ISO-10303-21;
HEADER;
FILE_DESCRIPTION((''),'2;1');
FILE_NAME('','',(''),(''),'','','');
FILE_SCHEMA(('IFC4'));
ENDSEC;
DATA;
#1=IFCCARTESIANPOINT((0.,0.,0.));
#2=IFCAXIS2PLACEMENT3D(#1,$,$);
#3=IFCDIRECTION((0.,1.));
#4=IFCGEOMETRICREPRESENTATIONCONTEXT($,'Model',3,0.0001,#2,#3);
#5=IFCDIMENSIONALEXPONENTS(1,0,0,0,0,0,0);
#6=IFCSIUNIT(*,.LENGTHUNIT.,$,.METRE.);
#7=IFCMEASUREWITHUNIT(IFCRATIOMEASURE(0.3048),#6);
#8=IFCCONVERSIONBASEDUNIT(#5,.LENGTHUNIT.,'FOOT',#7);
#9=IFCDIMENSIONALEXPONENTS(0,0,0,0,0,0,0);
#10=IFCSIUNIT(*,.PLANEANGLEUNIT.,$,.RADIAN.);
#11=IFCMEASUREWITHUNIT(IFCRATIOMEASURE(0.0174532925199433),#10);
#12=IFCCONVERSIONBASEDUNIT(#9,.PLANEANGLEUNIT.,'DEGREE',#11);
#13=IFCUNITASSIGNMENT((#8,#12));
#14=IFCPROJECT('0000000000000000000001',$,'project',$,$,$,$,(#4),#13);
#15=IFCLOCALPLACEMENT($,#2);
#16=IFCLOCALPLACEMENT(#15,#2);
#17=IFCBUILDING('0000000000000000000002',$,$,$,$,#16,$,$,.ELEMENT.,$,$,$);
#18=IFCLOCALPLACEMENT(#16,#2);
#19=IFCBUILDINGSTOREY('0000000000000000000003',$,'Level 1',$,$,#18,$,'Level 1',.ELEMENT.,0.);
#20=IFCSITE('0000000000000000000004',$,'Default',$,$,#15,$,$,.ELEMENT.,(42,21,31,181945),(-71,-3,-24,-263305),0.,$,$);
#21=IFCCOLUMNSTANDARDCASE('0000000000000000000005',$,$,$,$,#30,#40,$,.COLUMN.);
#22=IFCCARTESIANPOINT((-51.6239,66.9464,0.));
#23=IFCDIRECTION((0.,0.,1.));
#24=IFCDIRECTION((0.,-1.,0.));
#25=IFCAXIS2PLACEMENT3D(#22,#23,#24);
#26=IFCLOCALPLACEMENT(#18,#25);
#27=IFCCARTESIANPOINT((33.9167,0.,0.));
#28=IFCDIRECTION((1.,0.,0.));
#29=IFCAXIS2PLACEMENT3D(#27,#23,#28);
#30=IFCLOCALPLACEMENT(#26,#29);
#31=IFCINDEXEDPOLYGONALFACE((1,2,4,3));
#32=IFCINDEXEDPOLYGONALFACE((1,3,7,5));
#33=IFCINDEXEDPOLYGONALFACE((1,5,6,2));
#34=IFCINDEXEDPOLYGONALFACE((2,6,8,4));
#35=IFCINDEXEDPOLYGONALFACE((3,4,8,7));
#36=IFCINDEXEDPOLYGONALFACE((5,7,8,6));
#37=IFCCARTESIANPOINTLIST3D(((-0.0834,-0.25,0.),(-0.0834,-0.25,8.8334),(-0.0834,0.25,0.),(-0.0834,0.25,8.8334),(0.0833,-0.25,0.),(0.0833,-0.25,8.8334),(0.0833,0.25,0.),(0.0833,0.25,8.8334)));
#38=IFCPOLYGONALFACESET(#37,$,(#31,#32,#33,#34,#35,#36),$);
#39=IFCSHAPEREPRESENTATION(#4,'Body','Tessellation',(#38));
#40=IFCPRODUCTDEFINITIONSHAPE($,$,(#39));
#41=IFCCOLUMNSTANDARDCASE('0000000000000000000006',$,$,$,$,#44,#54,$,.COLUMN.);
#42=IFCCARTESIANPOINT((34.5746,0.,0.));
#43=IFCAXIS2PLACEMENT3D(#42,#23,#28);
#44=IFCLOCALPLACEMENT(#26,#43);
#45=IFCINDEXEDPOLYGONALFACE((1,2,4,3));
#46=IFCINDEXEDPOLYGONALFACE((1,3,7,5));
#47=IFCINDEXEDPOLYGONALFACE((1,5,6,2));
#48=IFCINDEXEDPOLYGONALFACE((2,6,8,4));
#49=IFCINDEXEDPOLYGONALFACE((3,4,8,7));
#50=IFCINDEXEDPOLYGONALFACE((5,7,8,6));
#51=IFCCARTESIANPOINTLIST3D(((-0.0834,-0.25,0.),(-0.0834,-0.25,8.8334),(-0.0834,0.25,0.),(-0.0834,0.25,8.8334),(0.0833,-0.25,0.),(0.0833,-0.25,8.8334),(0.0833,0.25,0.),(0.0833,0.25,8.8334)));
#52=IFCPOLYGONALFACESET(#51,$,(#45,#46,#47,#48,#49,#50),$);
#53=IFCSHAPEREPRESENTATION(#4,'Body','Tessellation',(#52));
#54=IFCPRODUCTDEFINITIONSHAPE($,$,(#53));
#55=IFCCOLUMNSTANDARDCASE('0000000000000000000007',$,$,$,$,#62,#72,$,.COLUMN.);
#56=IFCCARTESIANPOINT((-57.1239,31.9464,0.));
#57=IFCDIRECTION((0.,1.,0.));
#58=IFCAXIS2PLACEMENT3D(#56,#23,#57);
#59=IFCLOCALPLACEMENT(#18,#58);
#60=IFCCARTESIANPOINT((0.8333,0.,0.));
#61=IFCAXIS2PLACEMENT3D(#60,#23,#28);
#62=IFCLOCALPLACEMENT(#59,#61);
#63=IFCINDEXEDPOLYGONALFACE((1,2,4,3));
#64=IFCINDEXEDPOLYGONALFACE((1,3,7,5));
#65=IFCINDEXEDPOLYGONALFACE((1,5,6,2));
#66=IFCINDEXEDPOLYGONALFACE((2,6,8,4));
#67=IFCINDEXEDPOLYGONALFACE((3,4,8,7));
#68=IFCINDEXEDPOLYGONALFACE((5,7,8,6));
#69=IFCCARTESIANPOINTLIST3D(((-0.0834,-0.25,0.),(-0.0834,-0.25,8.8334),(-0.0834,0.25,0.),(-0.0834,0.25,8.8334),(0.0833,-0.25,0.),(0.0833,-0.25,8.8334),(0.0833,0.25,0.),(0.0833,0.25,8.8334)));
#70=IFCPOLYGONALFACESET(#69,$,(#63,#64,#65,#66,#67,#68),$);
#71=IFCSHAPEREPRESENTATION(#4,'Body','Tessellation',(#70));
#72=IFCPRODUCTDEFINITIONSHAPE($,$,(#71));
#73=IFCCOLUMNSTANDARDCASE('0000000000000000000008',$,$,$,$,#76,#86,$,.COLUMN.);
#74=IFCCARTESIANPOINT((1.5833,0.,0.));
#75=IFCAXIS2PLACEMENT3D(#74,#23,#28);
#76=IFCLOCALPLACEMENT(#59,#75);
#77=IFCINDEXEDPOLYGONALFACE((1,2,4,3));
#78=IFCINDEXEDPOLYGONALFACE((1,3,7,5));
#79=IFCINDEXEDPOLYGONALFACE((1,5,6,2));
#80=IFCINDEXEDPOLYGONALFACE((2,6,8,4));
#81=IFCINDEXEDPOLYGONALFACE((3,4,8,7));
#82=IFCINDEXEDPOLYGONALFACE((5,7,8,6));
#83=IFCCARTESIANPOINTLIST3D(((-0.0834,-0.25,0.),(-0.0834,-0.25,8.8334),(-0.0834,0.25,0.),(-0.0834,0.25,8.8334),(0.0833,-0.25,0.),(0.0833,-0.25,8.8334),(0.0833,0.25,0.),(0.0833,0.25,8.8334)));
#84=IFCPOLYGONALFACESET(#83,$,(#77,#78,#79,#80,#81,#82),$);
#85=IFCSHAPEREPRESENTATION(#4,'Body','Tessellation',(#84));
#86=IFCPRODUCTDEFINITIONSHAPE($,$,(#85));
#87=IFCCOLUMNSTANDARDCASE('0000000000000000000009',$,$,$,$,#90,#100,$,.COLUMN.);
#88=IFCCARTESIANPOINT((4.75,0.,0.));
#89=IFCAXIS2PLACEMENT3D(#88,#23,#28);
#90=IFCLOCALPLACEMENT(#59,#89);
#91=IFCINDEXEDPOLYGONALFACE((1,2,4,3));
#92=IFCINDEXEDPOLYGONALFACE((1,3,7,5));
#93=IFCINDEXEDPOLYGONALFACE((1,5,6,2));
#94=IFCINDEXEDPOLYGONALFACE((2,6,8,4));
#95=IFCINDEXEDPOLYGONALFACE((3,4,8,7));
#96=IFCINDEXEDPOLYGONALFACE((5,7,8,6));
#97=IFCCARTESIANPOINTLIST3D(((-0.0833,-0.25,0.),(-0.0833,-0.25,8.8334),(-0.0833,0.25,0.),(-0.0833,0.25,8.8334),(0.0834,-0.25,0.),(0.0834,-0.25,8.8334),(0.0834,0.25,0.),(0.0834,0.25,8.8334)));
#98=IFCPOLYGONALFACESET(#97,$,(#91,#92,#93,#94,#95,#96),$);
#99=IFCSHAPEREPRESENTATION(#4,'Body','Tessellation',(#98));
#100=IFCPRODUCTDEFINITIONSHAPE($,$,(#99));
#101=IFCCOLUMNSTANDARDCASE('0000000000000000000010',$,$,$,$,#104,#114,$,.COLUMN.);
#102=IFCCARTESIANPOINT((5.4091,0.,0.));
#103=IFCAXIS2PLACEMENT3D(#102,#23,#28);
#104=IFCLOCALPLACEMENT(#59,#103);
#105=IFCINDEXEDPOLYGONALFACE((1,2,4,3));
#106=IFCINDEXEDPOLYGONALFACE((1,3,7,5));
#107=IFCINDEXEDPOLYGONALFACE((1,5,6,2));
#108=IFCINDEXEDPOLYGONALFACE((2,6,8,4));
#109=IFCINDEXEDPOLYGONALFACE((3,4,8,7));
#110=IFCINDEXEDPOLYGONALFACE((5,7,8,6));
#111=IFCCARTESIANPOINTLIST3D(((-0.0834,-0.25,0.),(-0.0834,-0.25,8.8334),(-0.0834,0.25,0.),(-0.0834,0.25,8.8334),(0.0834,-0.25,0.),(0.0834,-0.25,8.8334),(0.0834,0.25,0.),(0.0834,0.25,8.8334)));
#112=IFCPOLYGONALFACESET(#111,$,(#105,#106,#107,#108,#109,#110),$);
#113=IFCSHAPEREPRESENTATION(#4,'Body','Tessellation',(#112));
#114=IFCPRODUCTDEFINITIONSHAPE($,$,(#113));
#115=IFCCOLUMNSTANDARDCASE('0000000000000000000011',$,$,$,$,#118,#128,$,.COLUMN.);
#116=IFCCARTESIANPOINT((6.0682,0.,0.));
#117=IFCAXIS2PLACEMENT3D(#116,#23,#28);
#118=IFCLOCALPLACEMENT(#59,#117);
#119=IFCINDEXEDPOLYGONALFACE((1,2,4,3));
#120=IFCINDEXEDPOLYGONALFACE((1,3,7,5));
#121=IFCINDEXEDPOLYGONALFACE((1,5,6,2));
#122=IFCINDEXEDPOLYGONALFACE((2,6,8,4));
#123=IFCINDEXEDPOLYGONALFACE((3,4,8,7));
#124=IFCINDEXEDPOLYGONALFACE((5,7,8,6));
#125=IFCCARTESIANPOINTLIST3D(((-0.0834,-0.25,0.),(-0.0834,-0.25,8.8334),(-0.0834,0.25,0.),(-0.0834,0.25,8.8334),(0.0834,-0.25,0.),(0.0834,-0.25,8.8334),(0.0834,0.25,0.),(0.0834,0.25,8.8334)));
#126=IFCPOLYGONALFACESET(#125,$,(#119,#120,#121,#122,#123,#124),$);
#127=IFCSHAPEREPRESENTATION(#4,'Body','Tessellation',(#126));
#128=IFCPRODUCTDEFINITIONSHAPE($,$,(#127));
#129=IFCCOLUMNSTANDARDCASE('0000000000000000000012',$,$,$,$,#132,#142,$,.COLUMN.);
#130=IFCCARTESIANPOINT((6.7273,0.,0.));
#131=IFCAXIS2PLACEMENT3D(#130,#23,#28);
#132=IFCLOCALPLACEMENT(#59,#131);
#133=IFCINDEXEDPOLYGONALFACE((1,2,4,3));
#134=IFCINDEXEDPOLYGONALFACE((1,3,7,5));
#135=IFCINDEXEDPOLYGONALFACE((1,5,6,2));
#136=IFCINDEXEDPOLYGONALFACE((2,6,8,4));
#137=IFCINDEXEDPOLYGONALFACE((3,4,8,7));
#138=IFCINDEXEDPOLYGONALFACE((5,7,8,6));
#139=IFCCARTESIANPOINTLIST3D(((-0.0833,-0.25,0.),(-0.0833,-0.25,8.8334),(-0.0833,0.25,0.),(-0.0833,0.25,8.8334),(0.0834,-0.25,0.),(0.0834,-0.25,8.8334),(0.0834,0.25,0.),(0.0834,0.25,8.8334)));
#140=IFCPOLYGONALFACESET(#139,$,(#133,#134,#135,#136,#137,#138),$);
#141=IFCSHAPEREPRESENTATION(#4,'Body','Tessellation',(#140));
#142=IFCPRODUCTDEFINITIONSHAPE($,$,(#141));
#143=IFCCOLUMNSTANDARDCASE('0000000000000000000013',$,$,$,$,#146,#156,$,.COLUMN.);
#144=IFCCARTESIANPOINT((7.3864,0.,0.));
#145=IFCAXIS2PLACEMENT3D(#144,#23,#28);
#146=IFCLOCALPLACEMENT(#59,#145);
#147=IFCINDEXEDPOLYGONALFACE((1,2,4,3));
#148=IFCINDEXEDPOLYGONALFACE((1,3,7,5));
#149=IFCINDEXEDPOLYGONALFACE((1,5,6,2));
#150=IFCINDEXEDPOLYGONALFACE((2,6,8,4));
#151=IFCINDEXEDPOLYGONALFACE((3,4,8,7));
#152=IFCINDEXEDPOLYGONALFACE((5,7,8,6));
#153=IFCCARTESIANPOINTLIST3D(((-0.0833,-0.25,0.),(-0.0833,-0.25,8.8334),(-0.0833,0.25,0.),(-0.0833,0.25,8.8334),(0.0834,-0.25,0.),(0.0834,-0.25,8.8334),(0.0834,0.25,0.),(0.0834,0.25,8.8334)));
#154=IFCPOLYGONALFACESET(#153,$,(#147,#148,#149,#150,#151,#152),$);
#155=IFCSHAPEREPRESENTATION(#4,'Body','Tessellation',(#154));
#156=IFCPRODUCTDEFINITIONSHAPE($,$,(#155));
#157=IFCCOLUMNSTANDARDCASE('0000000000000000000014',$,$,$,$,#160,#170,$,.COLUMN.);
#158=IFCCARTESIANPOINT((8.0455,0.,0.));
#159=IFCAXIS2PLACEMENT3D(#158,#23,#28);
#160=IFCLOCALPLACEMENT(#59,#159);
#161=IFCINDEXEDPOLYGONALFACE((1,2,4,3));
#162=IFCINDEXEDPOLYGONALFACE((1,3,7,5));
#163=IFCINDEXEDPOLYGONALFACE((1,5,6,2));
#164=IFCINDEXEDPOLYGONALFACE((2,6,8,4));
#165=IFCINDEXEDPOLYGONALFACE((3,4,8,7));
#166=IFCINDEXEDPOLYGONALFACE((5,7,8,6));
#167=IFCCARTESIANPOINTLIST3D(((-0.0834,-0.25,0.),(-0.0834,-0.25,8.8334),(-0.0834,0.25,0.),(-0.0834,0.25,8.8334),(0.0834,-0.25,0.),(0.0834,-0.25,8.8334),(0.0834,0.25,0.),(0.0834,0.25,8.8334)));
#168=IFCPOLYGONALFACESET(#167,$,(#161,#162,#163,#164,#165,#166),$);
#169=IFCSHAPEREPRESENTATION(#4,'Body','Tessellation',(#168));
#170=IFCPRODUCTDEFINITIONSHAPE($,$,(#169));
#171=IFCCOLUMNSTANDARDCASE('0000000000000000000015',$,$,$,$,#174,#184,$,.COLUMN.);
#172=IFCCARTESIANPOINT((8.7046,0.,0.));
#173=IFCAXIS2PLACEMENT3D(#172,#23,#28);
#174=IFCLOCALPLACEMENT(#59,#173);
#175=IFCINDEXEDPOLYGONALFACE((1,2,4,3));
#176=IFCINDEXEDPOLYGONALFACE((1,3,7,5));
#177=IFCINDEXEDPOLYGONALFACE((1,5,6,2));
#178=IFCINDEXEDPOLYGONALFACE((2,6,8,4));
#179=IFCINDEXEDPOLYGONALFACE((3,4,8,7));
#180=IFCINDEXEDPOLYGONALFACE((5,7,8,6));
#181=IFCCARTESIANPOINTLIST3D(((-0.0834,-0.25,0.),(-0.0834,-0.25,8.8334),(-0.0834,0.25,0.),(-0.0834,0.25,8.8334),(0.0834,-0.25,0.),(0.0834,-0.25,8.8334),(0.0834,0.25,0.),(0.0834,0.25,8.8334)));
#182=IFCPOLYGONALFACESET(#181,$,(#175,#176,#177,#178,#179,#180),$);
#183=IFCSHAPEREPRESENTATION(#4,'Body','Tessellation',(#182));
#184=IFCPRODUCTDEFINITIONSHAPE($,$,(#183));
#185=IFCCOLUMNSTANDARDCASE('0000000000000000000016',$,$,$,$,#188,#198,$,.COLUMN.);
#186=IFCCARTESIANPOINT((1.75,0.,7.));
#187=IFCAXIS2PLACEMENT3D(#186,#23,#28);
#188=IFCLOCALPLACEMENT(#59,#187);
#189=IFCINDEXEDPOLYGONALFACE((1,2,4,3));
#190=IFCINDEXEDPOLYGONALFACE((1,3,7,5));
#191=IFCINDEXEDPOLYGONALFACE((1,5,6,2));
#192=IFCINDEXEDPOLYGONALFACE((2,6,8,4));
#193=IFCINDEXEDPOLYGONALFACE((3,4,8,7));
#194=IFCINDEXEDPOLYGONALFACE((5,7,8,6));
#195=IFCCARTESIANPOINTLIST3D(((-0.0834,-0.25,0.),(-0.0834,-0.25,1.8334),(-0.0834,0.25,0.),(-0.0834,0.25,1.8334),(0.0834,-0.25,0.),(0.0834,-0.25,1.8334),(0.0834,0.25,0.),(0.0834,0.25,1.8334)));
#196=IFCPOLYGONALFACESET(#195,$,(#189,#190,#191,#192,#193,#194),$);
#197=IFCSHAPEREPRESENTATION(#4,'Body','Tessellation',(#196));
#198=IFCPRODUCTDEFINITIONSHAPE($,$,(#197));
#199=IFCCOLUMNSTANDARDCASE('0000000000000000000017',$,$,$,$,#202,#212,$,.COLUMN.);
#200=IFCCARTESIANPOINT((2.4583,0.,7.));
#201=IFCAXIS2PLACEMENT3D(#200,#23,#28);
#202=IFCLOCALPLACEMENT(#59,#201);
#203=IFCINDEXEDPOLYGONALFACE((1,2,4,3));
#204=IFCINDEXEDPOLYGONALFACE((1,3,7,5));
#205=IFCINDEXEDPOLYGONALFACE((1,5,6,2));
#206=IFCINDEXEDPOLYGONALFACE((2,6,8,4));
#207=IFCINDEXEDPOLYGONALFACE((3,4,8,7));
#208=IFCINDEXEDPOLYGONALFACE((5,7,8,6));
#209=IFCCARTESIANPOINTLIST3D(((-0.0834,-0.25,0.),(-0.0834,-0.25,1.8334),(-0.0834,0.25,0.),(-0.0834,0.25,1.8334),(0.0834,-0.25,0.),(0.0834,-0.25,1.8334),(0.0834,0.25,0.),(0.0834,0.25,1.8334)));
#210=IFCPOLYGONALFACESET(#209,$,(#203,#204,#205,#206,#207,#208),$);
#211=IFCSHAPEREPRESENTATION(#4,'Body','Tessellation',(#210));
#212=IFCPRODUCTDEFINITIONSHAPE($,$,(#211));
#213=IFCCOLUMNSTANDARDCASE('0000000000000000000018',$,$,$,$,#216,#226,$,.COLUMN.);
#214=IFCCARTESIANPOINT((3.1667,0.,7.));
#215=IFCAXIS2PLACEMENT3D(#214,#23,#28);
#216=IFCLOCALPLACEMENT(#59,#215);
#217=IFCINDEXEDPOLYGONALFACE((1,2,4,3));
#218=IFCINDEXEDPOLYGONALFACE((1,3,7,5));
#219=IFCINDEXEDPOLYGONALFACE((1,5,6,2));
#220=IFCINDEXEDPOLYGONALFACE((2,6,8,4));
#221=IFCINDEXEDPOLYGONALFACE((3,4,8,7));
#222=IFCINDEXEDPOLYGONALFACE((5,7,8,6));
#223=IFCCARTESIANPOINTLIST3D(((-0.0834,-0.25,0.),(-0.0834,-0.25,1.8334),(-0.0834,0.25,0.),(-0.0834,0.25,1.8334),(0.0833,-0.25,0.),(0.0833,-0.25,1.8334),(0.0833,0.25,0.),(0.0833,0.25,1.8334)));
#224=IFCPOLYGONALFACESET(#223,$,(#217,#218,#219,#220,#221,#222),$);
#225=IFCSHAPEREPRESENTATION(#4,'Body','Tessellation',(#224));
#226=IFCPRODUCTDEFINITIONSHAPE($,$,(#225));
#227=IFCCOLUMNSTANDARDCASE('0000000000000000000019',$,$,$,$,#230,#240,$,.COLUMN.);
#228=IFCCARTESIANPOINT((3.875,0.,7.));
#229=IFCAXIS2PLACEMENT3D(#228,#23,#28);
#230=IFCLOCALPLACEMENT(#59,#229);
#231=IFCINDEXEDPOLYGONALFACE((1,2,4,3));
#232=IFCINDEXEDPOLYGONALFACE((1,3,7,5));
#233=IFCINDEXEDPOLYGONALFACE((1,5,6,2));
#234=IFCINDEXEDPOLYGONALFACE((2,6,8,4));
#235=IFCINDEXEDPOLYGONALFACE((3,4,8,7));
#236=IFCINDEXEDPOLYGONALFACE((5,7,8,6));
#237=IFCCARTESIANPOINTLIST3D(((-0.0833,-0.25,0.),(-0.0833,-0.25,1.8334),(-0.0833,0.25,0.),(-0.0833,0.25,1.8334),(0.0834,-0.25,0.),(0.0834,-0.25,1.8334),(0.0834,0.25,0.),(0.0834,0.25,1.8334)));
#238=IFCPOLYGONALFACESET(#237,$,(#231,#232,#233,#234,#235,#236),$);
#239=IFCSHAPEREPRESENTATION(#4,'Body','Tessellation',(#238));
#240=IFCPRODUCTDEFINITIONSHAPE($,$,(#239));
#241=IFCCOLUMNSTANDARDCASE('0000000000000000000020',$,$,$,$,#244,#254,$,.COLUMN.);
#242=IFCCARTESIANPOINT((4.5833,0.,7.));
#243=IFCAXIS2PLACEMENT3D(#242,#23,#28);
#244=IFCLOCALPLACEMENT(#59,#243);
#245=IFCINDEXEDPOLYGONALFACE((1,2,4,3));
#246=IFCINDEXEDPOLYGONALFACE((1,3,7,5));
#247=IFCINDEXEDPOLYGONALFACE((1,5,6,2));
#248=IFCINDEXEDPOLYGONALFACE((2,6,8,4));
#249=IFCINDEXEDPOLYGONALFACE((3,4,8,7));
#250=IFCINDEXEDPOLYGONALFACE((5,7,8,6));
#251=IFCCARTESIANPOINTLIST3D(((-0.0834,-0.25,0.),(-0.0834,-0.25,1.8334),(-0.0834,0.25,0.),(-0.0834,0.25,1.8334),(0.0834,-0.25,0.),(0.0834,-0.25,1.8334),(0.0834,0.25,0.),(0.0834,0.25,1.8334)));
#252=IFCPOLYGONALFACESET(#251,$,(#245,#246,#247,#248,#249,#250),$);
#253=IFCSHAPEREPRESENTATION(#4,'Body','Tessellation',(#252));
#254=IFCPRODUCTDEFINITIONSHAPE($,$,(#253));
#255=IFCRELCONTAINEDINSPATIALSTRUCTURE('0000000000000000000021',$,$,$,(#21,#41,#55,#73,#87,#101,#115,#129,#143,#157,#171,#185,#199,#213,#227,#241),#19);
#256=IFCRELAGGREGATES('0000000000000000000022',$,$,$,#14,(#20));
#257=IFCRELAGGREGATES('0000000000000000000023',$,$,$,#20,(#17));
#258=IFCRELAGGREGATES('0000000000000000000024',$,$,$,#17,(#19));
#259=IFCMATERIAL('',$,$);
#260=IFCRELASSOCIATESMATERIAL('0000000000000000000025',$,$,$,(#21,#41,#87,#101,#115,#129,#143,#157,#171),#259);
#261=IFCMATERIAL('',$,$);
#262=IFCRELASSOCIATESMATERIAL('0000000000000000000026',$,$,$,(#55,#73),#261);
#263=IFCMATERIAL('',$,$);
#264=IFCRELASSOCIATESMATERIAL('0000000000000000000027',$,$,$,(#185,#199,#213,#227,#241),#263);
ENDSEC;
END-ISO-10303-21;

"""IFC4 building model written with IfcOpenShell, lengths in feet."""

from ifc_helpers import new_model, entity, si_unit, converted_unit, direction, frame, origin, place, context, project, spatial, rectangle, extrude, material, element, save


model = new_model("IFC4")

# Units and contexts
model_context = context("Model", 3, precision=0.0001, world=origin(), true_north=direction((0.0, 1.0)))
ifc_project = project(units=[converted_unit("LENGTHUNIT", "FOOT", entity("IfcRatioMeasure", 0.3048), si_unit("LENGTHUNIT", "METRE"), dimensions=[1, 0, 0, 0, 0, 0, 0]), converted_unit("PLANEANGLEUNIT", "DEGREE", entity("IfcRatioMeasure", 0.0174532925199433), si_unit("PLANEANGLEUNIT", "RADIAN"), dimensions=[0, 0, 0, 0, 0, 0, 0])], contexts=[model_context])

# Site, building, storey
site_placement = place(None, origin())
site = spatial("IfcSite", under=ifc_project, at=site_placement, Name="Default", CompositionType="ELEMENT", RefLatitude=(42, 21, 31, 181945), RefLongitude=(-71, -3, -24, -263305), RefElevation=0.0)
building_placement = place(site_placement, origin())
building = spatial("IfcBuilding", under=site, at=building_placement, CompositionType="ELEMENT")
storey_placement = place(building_placement, origin())
storey = spatial("IfcBuildingStorey", under=building, at=storey_placement, Name="Level 1", LongName="Level 1", CompositionType="ELEMENT", Elevation=0.0)

# Columns
ifc_material_1 = material(Name="")
placement_1 = place(storey_placement, frame((-51.6239, 66.9464, 0.0), z_axis=(0.0, 0.0, 1.0), x_axis=(0.0, -1.0, 0.0)))
for number, where, z_axis, x_axis in (
    (1, (33.9167, 0.0, 0.0), (0.0, 0.0, 1.0), (1.0, 0.0, 0.0)),
    (2, (34.5746, 0.0, 0.0), (0.0, 0.0, 1.0), (1.0, 0.0, 0.0)),
):
    element("IfcColumnStandardCase", number, at=place(placement_1, frame(where, z_axis=z_axis, x_axis=x_axis)), inside=storey, material=ifc_material_1, PredefinedType="COLUMN", context=model_context, shape_type="SweptSolid", body=[
        extrude(rectangle(XDim=0.1667, YDim=0.5), origin(), (0.0, 0.0, 1.0), 8.8334),
    ])
ifc_material_2 = material(Name="")
placement_2 = place(storey_placement, frame((-57.1239, 31.9464, 0.0), z_axis=(0.0, 0.0, 1.0), x_axis=(0.0, 1.0, 0.0)))
for number, where, z_axis, x_axis in (
    (3, (0.8333, 0.0, 0.0), (0.0, 0.0, 1.0), (1.0, 0.0, 0.0)),
    (4, (1.5833, 0.0, 0.0), (0.0, 0.0, 1.0), (1.0, 0.0, 0.0)),
):
    element("IfcColumnStandardCase", number, at=place(placement_2, frame(where, z_axis=z_axis, x_axis=x_axis)), inside=storey, material=ifc_material_2, PredefinedType="COLUMN", context=model_context, shape_type="SweptSolid", body=[
        extrude(rectangle(XDim=0.1667, YDim=0.5), origin(), (0.0, 0.0, 1.0), 8.8334),
    ])
for number, where, z_axis, x_axis in (
    (5, (4.75, 0.0, 0.0), (0.0, 0.0, 1.0), (1.0, 0.0, 0.0)),
    (6, (5.4091, 0.0, 0.0), (0.0, 0.0, 1.0), (1.0, 0.0, 0.0)),
    (7, (6.0682, 0.0, 0.0), (0.0, 0.0, 1.0), (1.0, 0.0, 0.0)),
    (8, (6.7273, 0.0, 0.0), (0.0, 0.0, 1.0), (1.0, 0.0, 0.0)),
    (9, (7.3864, 0.0, 0.0), (0.0, 0.0, 1.0), (1.0, 0.0, 0.0)),
    (10, (8.0455, 0.0, 0.0), (0.0, 0.0, 1.0), (1.0, 0.0, 0.0)),
    (11, (8.7046, 0.0, 0.0), (0.0, 0.0, 1.0), (1.0, 0.0, 0.0)),
):
    element("IfcColumnStandardCase", number, at=place(placement_2, frame(where, z_axis=z_axis, x_axis=x_axis)), inside=storey, material=ifc_material_1, PredefinedType="COLUMN", context=model_context, shape_type="SweptSolid", body=[
        extrude(rectangle(XDim=0.1667, YDim=0.5), origin(), (0.0, 0.0, 1.0), 8.8334),
    ])
ifc_material_3 = material(Name="")
for number, where, z_axis, x_axis in (
    (12, (1.75, 0.0, 7.0), (0.0, 0.0, 1.0), (1.0, 0.0, 0.0)),
    (13, (2.4583, 0.0, 7.0), (0.0, 0.0, 1.0), (1.0, 0.0, 0.0)),
    (14, (3.1667, 0.0, 7.0), (0.0, 0.0, 1.0), (1.0, 0.0, 0.0)),
    (15, (3.875, 0.0, 7.0), (0.0, 0.0, 1.0), (1.0, 0.0, 0.0)),
    (16, (4.5833, 0.0, 7.0), (0.0, 0.0, 1.0), (1.0, 0.0, 0.0)),
):
    element("IfcColumnStandardCase", number, at=place(placement_2, frame(where, z_axis=z_axis, x_axis=x_axis)), inside=storey, material=ifc_material_3, PredefinedType="COLUMN", context=model_context, shape_type="SweptSolid", body=[
        extrude(rectangle(XDim=0.1667, YDim=0.5), origin(), (0.0, 0.0, 1.0), 1.8334),
    ])

save(model, "model.ifc")
